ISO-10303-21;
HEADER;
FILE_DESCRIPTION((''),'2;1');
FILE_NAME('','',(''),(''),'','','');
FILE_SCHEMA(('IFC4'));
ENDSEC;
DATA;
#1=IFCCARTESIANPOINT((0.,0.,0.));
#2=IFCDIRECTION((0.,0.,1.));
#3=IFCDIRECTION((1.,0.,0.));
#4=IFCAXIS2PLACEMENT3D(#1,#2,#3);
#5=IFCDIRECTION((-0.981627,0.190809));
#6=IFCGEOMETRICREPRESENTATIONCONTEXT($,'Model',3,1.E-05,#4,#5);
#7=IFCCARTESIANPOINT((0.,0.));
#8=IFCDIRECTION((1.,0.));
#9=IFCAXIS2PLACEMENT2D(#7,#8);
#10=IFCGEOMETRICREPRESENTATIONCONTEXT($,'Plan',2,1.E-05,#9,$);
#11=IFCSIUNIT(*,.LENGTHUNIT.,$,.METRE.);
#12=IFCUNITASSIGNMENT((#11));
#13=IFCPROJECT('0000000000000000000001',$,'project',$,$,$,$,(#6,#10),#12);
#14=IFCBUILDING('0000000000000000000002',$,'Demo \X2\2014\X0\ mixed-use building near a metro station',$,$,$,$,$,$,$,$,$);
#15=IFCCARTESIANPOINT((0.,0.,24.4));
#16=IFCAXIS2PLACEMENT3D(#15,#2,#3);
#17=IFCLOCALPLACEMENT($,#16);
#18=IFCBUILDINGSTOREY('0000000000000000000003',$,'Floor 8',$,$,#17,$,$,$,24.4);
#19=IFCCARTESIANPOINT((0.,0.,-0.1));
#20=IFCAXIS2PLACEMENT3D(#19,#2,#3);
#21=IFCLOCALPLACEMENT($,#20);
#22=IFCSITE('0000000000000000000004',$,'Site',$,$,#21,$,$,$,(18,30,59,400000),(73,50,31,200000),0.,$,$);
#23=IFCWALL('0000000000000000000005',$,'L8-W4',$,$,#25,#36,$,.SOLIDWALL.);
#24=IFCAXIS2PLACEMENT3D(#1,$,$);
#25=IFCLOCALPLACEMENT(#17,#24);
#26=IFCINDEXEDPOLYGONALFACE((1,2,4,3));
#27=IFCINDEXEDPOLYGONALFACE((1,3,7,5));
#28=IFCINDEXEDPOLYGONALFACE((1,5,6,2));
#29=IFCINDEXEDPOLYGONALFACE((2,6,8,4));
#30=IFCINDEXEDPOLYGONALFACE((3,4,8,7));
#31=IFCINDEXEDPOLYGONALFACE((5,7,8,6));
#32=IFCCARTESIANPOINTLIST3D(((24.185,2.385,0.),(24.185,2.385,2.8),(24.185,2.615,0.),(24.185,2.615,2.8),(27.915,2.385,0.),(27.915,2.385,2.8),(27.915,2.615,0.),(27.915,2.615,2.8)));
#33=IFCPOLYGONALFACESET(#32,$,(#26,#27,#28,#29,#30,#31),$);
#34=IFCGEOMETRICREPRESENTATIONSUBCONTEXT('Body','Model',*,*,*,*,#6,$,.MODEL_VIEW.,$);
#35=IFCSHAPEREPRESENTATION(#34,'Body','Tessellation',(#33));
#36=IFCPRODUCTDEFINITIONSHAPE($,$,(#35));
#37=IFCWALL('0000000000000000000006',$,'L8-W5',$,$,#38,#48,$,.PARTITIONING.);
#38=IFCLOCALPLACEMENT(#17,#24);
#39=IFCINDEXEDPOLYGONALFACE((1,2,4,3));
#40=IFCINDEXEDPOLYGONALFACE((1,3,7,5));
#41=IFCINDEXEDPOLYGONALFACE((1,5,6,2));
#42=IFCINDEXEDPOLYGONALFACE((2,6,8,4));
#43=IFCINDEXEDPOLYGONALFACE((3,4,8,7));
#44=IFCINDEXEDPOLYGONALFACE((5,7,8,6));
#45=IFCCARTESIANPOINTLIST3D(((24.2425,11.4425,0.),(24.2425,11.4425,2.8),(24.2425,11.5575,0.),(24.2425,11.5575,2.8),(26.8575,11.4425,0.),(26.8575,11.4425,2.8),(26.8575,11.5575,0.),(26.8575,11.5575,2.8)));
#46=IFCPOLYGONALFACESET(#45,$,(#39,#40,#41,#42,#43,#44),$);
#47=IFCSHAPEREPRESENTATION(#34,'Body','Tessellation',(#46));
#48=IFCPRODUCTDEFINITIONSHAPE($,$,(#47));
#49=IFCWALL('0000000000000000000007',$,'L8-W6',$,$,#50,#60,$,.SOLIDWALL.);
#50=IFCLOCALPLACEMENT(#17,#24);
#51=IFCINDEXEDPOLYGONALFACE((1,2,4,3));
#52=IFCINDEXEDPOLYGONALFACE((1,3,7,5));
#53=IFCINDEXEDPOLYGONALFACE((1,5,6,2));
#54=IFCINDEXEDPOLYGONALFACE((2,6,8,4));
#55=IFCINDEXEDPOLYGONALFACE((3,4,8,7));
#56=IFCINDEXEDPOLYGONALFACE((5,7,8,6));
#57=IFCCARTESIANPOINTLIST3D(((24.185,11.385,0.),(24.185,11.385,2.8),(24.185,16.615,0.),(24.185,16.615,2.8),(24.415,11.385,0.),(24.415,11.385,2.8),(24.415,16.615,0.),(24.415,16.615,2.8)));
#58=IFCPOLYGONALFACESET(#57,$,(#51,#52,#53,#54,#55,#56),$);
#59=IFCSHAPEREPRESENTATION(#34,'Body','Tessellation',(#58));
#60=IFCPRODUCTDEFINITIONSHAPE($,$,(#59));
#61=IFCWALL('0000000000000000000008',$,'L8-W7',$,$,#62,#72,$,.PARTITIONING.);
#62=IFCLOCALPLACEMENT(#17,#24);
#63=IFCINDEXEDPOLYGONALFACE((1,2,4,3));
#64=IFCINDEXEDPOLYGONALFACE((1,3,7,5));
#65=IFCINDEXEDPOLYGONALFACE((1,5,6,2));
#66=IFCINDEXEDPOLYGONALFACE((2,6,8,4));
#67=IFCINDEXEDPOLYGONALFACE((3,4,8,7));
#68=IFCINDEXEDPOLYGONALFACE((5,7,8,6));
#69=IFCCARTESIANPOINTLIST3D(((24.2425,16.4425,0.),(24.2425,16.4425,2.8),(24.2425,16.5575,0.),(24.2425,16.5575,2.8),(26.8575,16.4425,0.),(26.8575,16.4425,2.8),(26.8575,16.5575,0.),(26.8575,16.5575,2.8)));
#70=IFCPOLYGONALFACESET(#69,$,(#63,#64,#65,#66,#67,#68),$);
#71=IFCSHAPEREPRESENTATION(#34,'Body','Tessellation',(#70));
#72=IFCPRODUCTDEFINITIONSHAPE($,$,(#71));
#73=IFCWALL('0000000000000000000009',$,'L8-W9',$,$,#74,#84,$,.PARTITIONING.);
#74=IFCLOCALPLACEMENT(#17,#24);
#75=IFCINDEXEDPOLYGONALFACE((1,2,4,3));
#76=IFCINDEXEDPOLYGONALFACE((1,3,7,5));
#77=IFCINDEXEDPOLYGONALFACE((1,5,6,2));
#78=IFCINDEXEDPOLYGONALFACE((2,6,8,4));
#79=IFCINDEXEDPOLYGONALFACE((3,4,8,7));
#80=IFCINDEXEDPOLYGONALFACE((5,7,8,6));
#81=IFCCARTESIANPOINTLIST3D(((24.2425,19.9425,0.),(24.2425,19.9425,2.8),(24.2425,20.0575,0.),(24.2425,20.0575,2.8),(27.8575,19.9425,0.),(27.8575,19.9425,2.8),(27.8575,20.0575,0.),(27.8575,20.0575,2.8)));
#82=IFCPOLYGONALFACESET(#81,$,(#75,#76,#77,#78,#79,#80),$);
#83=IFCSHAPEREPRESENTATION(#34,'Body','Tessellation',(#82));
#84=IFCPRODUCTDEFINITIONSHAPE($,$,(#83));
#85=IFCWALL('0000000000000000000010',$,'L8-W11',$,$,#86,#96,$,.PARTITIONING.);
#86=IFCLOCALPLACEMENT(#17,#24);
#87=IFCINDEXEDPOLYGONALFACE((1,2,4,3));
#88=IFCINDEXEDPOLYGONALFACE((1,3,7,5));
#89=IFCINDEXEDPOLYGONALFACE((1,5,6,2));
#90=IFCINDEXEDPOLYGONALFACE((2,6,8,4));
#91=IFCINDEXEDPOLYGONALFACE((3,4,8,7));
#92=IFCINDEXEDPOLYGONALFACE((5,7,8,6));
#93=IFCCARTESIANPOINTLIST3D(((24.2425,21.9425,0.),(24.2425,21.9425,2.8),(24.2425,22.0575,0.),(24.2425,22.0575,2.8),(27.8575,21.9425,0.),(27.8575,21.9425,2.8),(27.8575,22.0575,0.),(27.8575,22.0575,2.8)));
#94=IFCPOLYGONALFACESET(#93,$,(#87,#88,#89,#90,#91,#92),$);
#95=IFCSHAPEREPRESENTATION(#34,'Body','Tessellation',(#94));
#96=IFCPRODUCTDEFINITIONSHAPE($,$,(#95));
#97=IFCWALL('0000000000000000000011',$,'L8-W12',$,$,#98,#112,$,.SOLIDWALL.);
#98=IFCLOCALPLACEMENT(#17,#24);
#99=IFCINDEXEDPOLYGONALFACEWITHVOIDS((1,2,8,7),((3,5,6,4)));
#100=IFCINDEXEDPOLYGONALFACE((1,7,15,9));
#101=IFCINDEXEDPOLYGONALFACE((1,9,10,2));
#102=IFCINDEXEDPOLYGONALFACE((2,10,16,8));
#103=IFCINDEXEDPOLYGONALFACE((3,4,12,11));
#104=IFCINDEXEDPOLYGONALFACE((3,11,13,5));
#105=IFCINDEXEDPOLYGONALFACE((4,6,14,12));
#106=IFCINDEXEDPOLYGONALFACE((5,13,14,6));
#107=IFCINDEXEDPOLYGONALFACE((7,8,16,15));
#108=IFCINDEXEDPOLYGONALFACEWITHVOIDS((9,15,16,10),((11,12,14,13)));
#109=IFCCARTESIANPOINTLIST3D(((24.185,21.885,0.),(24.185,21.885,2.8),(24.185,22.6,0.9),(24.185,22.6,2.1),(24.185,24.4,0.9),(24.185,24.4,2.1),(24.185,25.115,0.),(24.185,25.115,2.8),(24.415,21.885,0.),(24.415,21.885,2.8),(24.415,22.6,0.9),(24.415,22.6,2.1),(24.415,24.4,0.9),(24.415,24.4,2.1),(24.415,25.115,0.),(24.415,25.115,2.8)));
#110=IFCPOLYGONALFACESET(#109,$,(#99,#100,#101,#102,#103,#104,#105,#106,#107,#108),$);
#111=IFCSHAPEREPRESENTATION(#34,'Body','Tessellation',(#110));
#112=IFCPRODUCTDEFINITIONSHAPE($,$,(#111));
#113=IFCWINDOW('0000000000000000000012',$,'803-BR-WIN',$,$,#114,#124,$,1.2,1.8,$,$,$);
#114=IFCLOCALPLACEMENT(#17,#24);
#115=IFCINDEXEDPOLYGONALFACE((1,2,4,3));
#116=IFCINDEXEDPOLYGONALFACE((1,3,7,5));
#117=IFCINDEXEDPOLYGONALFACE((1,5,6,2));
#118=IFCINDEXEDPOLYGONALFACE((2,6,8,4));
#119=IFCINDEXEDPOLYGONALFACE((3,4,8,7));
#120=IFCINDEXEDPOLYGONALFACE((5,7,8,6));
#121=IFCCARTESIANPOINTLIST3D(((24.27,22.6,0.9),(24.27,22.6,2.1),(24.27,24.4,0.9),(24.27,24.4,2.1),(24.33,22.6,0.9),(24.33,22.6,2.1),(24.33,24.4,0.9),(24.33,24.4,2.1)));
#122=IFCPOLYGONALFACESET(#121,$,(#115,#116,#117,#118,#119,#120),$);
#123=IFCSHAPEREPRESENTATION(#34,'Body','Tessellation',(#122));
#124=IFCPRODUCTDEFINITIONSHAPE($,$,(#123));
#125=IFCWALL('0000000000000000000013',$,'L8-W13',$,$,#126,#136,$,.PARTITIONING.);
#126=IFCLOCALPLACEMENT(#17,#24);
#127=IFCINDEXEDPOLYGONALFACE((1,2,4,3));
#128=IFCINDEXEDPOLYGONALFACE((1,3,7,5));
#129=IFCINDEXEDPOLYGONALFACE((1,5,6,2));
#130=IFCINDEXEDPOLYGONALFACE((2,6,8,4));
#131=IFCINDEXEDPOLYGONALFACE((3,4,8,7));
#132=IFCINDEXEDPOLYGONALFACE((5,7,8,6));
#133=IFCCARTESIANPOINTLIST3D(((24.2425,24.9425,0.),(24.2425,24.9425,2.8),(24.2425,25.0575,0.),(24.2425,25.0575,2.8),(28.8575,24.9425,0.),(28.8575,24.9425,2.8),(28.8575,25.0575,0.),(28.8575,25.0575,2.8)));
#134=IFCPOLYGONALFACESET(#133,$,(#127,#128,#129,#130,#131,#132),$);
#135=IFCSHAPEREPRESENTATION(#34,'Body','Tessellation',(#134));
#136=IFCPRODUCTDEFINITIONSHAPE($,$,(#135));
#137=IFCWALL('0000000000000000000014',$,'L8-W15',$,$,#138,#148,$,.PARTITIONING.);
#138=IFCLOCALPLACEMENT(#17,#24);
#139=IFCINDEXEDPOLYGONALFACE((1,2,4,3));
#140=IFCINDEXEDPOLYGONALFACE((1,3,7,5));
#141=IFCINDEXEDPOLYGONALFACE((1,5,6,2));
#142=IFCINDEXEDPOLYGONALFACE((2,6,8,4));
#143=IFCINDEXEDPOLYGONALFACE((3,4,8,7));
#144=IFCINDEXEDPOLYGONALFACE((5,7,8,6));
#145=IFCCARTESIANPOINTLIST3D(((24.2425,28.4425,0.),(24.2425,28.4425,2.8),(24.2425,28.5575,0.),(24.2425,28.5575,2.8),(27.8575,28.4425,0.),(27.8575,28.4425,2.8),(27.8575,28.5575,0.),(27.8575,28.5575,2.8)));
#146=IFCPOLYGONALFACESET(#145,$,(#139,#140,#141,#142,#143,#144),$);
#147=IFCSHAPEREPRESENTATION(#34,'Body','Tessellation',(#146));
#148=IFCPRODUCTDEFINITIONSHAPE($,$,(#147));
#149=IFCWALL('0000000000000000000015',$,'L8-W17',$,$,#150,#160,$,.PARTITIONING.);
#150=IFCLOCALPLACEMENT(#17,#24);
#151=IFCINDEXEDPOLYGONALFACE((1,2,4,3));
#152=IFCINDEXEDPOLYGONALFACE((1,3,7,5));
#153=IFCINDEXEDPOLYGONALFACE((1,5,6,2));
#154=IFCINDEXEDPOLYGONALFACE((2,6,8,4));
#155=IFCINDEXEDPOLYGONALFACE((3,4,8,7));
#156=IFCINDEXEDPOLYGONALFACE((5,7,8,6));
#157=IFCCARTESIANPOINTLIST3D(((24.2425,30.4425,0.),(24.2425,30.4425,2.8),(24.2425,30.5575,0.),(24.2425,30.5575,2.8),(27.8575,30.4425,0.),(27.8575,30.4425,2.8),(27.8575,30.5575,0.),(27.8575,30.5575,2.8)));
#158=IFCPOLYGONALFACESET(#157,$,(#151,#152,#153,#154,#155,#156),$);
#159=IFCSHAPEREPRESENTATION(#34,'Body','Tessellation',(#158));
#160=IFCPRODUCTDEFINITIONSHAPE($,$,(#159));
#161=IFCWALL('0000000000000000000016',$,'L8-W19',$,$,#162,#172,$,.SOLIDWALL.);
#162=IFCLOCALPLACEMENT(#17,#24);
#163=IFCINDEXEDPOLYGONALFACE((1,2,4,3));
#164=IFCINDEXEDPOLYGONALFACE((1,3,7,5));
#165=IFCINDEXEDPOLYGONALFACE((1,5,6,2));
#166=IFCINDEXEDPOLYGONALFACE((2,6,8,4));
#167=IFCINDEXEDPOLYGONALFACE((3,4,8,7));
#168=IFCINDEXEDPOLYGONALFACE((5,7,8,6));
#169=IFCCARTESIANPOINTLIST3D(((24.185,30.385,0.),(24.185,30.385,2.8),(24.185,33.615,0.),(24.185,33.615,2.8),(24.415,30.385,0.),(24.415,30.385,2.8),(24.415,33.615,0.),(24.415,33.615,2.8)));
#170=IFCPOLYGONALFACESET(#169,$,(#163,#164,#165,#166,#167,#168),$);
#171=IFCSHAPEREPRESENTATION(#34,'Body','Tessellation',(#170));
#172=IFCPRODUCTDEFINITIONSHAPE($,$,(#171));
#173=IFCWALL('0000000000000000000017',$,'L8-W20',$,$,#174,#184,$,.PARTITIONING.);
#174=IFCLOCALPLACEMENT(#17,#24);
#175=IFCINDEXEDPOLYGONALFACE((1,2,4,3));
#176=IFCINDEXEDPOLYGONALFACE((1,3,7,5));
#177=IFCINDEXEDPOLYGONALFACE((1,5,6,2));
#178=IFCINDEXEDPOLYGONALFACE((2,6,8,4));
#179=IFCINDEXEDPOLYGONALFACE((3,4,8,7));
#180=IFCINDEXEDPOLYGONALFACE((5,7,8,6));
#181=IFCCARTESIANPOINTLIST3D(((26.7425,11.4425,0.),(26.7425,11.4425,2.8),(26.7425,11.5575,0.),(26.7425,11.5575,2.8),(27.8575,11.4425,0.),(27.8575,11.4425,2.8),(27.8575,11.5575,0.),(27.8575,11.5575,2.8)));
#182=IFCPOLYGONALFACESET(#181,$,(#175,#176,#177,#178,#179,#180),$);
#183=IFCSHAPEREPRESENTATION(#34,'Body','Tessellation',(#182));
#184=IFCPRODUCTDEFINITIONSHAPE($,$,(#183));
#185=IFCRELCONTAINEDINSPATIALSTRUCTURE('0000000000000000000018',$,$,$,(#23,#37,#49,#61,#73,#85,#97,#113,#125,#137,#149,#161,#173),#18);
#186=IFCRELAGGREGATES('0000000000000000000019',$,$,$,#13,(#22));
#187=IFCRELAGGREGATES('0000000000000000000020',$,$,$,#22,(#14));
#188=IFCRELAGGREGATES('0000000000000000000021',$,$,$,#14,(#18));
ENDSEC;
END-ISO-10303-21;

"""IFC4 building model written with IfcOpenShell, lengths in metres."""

from ifc_helpers import new_model, si_unit, direction, frame, origin_with_axes, origin_2d_with_axis, place, context, subcontext, project, spatial, line, indexed_curve, outline, extrude, element, fill, save


model = new_model("IFC4")

# Units and contexts
model_context = context("Model", 3, precision=1e-05, world=origin_with_axes(), true_north=direction((-0.981627, 0.190809)))
plan_context = context("Plan", 2, precision=1e-05, world=origin_2d_with_axis())
body_context = subcontext(model_context, "Body", "Model", "MODEL_VIEW")
ifc_project = project(units=[si_unit("LENGTHUNIT", "METRE")], contexts=[model_context, plan_context])

# Site, building, storey
site_placement = place(None, frame((0.0, 0.0, -0.1), z_axis=(0.0, 0.0, 1.0), x_axis=(1.0, 0.0, 0.0)))
site = spatial("IfcSite", under=ifc_project, at=site_placement, Name="Site", RefLatitude=(18, 30, 59, 400000), RefLongitude=(73, 50, 31, 200000), RefElevation=0.0)
building = spatial("IfcBuilding", under=site, Name="Demo — mixed-use building near a metro station")
storey_placement = place(None, frame((0.0, 0.0, 24.4), z_axis=(0.0, 0.0, 1.0), x_axis=(1.0, 0.0, 0.0)))
storey = spatial("IfcBuildingStorey", under=building, at=storey_placement, Name="Floor 8", Elevation=24.4)

# Walls
wall_1_placement = place(storey_placement, frame((0.0, 0.0, -24.4), z_axis=(0.0, 0.0, 1.0), x_axis=(1.0, 0.0, 0.0)))
element("IfcWall", 1, at=wall_1_placement, inside=storey, Name="L8-W4", PredefinedType="SOLIDWALL", context=body_context, shape_type="SweptSolid", body=[
    extrude(outline(indexed_curve([(24.185, 2.615), (27.915, 2.615), (27.915, 2.385), (24.185, 2.385)], segments=[line(1, 2, 3, 4, 1)])), frame((0.0, 0.0, 24.4), z_axis=(0.0, 0.0, 1.0), x_axis=(1.0, 0.0, 0.0)), (0.0, 0.0, 1.0), 2.8),
])
wall_2_placement = place(storey_placement, frame((0.0, 0.0, -24.4), z_axis=(0.0, 0.0, 1.0), x_axis=(1.0, 0.0, 0.0)))
element("IfcWall", 2, at=wall_2_placement, inside=storey, Name="L8-W5", PredefinedType="PARTITIONING", context=body_context, shape_type="SweptSolid", body=[
    extrude(outline(indexed_curve([(24.2425, 11.5575), (26.8575, 11.5575), (26.8575, 11.4425), (24.2425, 11.4425)], segments=[line(1, 2, 3, 4, 1)])), frame((0.0, 0.0, 24.4), z_axis=(0.0, 0.0, 1.0), x_axis=(1.0, 0.0, 0.0)), (0.0, 0.0, 1.0), 2.8),
])
wall_3_placement = place(storey_placement, frame((0.0, 0.0, -24.4), z_axis=(0.0, 0.0, 1.0), x_axis=(1.0, 0.0, 0.0)))
element("IfcWall", 3, at=wall_3_placement, inside=storey, Name="L8-W6", PredefinedType="SOLIDWALL", context=body_context, shape_type="SweptSolid", body=[
    extrude(outline(indexed_curve([(24.415, 16.615), (24.415, 11.385), (24.185, 11.385), (24.185, 16.615)], segments=[line(1, 2, 3, 4, 1)])), frame((0.0, 0.0, 24.4), z_axis=(0.0, 0.0, 1.0), x_axis=(1.0, 0.0, 0.0)), (0.0, 0.0, 1.0), 2.8),
])
wall_4_placement = place(storey_placement, frame((0.0, 0.0, -24.4), z_axis=(0.0, 0.0, 1.0), x_axis=(1.0, 0.0, 0.0)))
element("IfcWall", 4, at=wall_4_placement, inside=storey, Name="L8-W7", PredefinedType="PARTITIONING", context=body_context, shape_type="SweptSolid", body=[
    extrude(outline(indexed_curve([(26.8575, 16.4425), (24.2425, 16.4425), (24.2425, 16.5575), (26.8575, 16.5575)], segments=[line(1, 2, 3, 4, 1)])), frame((0.0, 0.0, 24.4), z_axis=(0.0, 0.0, 1.0), x_axis=(1.0, 0.0, 0.0)), (0.0, 0.0, 1.0), 2.8),
])

# Wall
wall_5_placement = place(storey_placement, frame((0.0, 0.0, -24.4), z_axis=(0.0, 0.0, 1.0), x_axis=(1.0, 0.0, 0.0)))
element("IfcWall", 5, at=wall_5_placement, inside=storey, Name="L8-W9", PredefinedType="PARTITIONING", context=body_context, shape_type="SweptSolid", body=[
    extrude(outline(indexed_curve([(27.8575, 19.9425), (24.2425, 19.9425), (24.2425, 20.0575), (27.8575, 20.0575)], segments=[line(1, 2, 3, 4, 1)])), frame((0.0, 0.0, 24.4), z_axis=(0.0, 0.0, 1.0), x_axis=(1.0, 0.0, 0.0)), (0.0, 0.0, 1.0), 2.8),
])

# Wall
wall_6_placement = place(storey_placement, frame((0.0, 0.0, -24.4), z_axis=(0.0, 0.0, 1.0), x_axis=(1.0, 0.0, 0.0)))
element("IfcWall", 6, at=wall_6_placement, inside=storey, Name="L8-W11", PredefinedType="PARTITIONING", context=body_context, shape_type="SweptSolid", body=[
    extrude(outline(indexed_curve([(27.8575, 21.9425), (24.2425, 21.9425), (24.2425, 22.0575), (27.8575, 22.0575)], segments=[line(1, 2, 3, 4, 1)])), frame((0.0, 0.0, 24.4), z_axis=(0.0, 0.0, 1.0), x_axis=(1.0, 0.0, 0.0)), (0.0, 0.0, 1.0), 2.8),
])

# Wall, opening, window
wall_7_placement = place(storey_placement, frame((0.0, 0.0, -24.4), z_axis=(0.0, 0.0, 1.0), x_axis=(1.0, 0.0, 0.0)))
wall_7 = element("IfcWall", 7, at=wall_7_placement, inside=storey, Name="L8-W12", PredefinedType="SOLIDWALL", context=body_context, shape_type="SweptSolid", body=[
    extrude(outline(indexed_curve([(24.415, 25.115), (24.415, 21.885), (24.185, 21.885), (24.185, 25.115)], segments=[line(1, 2, 3, 4, 1)])), frame((0.0, 0.0, 24.4), z_axis=(0.0, 0.0, 1.0), x_axis=(1.0, 0.0, 0.0)), (0.0, 0.0, 1.0), 2.8),
])
opening_1_placement = place(wall_7_placement, origin_with_axes())
opening_1 = element("IfcOpeningElement", 8, at=opening_1_placement, cuts=wall_7, context=body_context, shape_type="SweptSolid", body=[
    extrude(outline(indexed_curve([(24.465, 24.4), (24.465, 22.6), (24.135, 22.6), (24.135, 24.4)], segments=[line(1, 2, 3, 4, 1)])), frame((0.0, 0.0, 25.3), z_axis=(0.0, 0.0, 1.0), x_axis=(1.0, 0.0, 0.0)), (0.0, 0.0, 1.0), 1.2),
])
window_1_placement = place(storey_placement, frame((0.0, 0.0, -24.4), z_axis=(0.0, 0.0, 1.0), x_axis=(1.0, 0.0, 0.0)))
window_1 = element("IfcWindow", 9, at=window_1_placement, inside=storey, Name="803-BR-WIN", OverallHeight=1.2, OverallWidth=1.8, context=body_context, shape_type="SweptSolid", body=[
    extrude(outline(indexed_curve([(24.33, 24.4), (24.33, 22.6), (24.27, 22.6), (24.27, 24.4)], segments=[line(1, 2, 3, 4, 1)])), frame((0.0, 0.0, 25.3), z_axis=(0.0, 0.0, 1.0), x_axis=(1.0, 0.0, 0.0)), (0.0, 0.0, 1.0), 1.2),
])
fill(opening_1, window_1)

# Wall
wall_8_placement = place(storey_placement, frame((0.0, 0.0, -24.4), z_axis=(0.0, 0.0, 1.0), x_axis=(1.0, 0.0, 0.0)))
element("IfcWall", 10, at=wall_8_placement, inside=storey, Name="L8-W13", PredefinedType="PARTITIONING", context=body_context, shape_type="SweptSolid", body=[
    extrude(outline(indexed_curve([(28.8575, 24.9425), (24.2425, 24.9425), (24.2425, 25.0575), (28.8575, 25.0575)], segments=[line(1, 2, 3, 4, 1)])), frame((0.0, 0.0, 24.4), z_axis=(0.0, 0.0, 1.0), x_axis=(1.0, 0.0, 0.0)), (0.0, 0.0, 1.0), 2.8),
])

# Wall
wall_9_placement = place(storey_placement, frame((0.0, 0.0, -24.4), z_axis=(0.0, 0.0, 1.0), x_axis=(1.0, 0.0, 0.0)))
element("IfcWall", 11, at=wall_9_placement, inside=storey, Name="L8-W15", PredefinedType="PARTITIONING", context=body_context, shape_type="SweptSolid", body=[
    extrude(outline(indexed_curve([(27.8575, 28.4425), (24.2425, 28.4425), (24.2425, 28.5575), (27.8575, 28.5575)], segments=[line(1, 2, 3, 4, 1)])), frame((0.0, 0.0, 24.4), z_axis=(0.0, 0.0, 1.0), x_axis=(1.0, 0.0, 0.0)), (0.0, 0.0, 1.0), 2.8),
])

# Wall
wall_10_placement = place(storey_placement, frame((0.0, 0.0, -24.4), z_axis=(0.0, 0.0, 1.0), x_axis=(1.0, 0.0, 0.0)))
element("IfcWall", 12, at=wall_10_placement, inside=storey, Name="L8-W17", PredefinedType="PARTITIONING", context=body_context, shape_type="SweptSolid", body=[
    extrude(outline(indexed_curve([(27.8575, 30.4425), (24.2425, 30.4425), (24.2425, 30.5575), (27.8575, 30.5575)], segments=[line(1, 2, 3, 4, 1)])), frame((0.0, 0.0, 24.4), z_axis=(0.0, 0.0, 1.0), x_axis=(1.0, 0.0, 0.0)), (0.0, 0.0, 1.0), 2.8),
])

# Walls
wall_11_placement = place(storey_placement, frame((0.0, 0.0, -24.4), z_axis=(0.0, 0.0, 1.0), x_axis=(1.0, 0.0, 0.0)))
element("IfcWall", 13, at=wall_11_placement, inside=storey, Name="L8-W19", PredefinedType="SOLIDWALL", context=body_context, shape_type="SweptSolid", body=[
    extrude(outline(indexed_curve([(24.415, 33.615), (24.415, 30.385), (24.185, 30.385), (24.185, 33.615)], segments=[line(1, 2, 3, 4, 1)])), frame((0.0, 0.0, 24.4), z_axis=(0.0, 0.0, 1.0), x_axis=(1.0, 0.0, 0.0)), (0.0, 0.0, 1.0), 2.8),
])
wall_12_placement = place(storey_placement, frame((0.0, 0.0, -24.4), z_axis=(0.0, 0.0, 1.0), x_axis=(1.0, 0.0, 0.0)))
element("IfcWall", 14, at=wall_12_placement, inside=storey, Name="L8-W20", PredefinedType="PARTITIONING", context=body_context, shape_type="SweptSolid", body=[
    extrude(outline(indexed_curve([(26.7425, 11.5575), (27.8575, 11.5575), (27.8575, 11.4425), (26.7425, 11.4425)], segments=[line(1, 2, 3, 4, 1)])), frame((0.0, 0.0, 24.4), z_axis=(0.0, 0.0, 1.0), x_axis=(1.0, 0.0, 0.0)), (0.0, 0.0, 1.0), 2.8),
])

save(model, "model.ifc")
